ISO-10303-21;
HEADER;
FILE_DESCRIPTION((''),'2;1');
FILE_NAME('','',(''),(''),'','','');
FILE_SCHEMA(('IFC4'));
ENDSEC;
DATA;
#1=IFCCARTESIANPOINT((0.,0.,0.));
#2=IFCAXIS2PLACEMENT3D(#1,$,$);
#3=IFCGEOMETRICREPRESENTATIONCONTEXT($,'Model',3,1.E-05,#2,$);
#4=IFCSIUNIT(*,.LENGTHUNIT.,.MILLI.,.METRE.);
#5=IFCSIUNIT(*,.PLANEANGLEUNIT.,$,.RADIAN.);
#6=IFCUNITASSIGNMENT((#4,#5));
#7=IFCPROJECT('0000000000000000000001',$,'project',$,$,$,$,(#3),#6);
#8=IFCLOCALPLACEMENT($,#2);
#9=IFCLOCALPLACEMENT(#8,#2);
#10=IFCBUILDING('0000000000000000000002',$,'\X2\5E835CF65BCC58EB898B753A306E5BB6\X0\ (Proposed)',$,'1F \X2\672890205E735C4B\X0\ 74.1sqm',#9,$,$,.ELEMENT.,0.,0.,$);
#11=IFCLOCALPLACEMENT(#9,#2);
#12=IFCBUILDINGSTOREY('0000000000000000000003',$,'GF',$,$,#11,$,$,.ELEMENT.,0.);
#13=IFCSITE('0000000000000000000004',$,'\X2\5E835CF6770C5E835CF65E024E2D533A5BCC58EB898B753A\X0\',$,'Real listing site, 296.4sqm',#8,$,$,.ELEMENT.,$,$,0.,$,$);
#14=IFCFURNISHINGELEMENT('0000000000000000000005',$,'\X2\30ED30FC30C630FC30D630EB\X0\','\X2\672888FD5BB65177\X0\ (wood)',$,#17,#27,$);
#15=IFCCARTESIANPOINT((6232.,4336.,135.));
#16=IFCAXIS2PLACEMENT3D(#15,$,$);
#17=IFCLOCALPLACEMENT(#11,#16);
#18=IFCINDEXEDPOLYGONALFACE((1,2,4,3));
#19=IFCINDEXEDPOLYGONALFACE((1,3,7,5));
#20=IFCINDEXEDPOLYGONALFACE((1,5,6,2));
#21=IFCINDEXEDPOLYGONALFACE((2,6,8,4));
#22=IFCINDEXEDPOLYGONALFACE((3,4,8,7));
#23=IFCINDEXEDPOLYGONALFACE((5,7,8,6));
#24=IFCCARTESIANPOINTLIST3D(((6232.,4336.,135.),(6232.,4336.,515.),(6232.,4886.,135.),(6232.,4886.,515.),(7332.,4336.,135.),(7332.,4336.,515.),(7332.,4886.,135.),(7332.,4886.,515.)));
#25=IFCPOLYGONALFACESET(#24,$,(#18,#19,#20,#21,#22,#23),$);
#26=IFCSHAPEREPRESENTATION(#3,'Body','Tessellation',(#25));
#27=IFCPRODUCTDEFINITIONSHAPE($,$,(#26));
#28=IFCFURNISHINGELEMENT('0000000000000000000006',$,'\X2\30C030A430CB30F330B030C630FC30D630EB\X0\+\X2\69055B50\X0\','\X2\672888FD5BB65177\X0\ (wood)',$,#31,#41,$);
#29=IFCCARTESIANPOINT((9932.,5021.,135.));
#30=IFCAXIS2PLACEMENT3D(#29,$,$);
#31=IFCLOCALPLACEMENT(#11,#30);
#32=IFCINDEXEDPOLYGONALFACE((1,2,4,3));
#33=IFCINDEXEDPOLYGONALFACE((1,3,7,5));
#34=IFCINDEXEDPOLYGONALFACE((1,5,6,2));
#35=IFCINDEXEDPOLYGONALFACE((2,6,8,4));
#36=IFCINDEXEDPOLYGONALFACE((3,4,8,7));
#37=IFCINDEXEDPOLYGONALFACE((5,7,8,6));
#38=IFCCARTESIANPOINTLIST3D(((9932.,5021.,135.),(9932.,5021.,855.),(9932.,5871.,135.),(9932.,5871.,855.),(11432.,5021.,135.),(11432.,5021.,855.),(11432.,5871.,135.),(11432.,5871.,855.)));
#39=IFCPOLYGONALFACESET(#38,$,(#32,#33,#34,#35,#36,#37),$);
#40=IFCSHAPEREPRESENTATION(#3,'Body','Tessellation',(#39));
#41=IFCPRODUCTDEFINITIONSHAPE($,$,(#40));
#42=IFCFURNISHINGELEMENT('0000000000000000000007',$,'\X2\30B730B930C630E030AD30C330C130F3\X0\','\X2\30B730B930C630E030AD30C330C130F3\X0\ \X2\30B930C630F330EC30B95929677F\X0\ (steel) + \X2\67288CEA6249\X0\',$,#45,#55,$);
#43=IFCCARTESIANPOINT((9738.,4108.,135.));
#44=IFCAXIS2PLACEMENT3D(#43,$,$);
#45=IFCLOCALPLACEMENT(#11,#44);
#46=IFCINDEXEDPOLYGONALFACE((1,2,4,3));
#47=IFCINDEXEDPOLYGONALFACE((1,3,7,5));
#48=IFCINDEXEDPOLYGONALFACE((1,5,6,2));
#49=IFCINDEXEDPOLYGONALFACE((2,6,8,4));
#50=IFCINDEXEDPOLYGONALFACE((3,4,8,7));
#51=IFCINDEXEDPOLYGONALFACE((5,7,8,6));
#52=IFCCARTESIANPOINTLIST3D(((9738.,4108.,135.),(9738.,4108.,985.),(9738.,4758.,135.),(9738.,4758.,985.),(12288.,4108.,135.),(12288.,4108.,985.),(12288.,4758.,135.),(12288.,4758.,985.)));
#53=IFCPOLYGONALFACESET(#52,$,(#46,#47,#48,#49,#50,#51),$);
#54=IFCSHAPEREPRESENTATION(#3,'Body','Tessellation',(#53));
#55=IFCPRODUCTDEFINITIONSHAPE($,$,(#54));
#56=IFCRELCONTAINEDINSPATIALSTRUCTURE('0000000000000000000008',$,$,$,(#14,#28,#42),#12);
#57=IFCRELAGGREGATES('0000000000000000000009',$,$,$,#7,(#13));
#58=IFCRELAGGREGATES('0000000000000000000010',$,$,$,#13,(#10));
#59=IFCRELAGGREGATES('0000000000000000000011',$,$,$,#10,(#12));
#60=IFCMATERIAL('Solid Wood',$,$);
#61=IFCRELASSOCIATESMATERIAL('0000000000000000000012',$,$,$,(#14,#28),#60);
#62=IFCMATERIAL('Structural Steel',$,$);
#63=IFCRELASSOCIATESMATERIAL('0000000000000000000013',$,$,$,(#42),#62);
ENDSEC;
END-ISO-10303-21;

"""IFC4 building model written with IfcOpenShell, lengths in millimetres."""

from ifc_helpers import new_model, si_unit, frame, frame_2d, origin, place, context, project, spatial, rectangle, extrude, material, element, save


model = new_model("IFC4")

# Units and contexts
model_context = context("Model", 3, precision=1e-05, world=origin())
ifc_project = project(units=[si_unit("LENGTHUNIT", "METRE", prefix="MILLI"), si_unit("PLANEANGLEUNIT", "RADIAN")], contexts=[model_context])

# Site, building, storey
site_placement = place(None, origin())
site = spatial("IfcSite", under=ifc_project, at=site_placement, Name="広島県広島市中区富士見町", ObjectType="Real listing site, 296.4sqm", CompositionType="ELEMENT", RefElevation=0.0)
building_placement = place(site_placement, origin())
building = spatial("IfcBuilding", under=site, at=building_placement, Name="広島富士見町の家 (Proposed)", ObjectType="1F 木造平屋 74.1sqm", CompositionType="ELEMENT", ElevationOfRefHeight=0.0, ElevationOfTerrain=0.0)
storey_placement = place(building_placement, origin())
storey = spatial("IfcBuildingStorey", under=building, at=storey_placement, Name="GF", CompositionType="ELEMENT", Elevation=0.0)

# Shared definitions
ifc_material_1 = material(Name="Solid Wood")

# Furnishing elements
furnishing_1_placement = place(storey_placement, frame((6232.0, 4336.0, 135.0)))
element("IfcFurnishingElement", 1, at=furnishing_1_placement, inside=storey, material=ifc_material_1, Name="ローテーブル", Description="木製家具 (wood)", context=model_context, shape_type="SweptSolid", body=[
    extrude(rectangle(XDim=1100.0, YDim=550.0, at=frame_2d((550.0, 275.0))), frame((6232.0, 4336.0, 135.0)), (0.0, 0.0, 1.0), 380.0),
])
furnishing_2_placement = place(storey_placement, frame((9932.0, 5021.0, 135.0)))
element("IfcFurnishingElement", 2, at=furnishing_2_placement, inside=storey, material=ifc_material_1, Name="ダイニングテーブル+椅子", Description="木製家具 (wood)", context=model_context, shape_type="SweptSolid", body=[
    extrude(rectangle(XDim=1500.0, YDim=850.0, at=frame_2d((750.0, 425.0))), frame((9932.0, 5021.0, 135.0)), (0.0, 0.0, 1.0), 720.0),
])
ifc_material_2 = material(Name="Structural Steel")
furnishing_3_placement = place(storey_placement, frame((9738.0, 4108.0, 135.0)))
element("IfcFurnishingElement", 3, at=furnishing_3_placement, inside=storey, material=ifc_material_2, Name="システムキッチン", Description="システムキッチン ステンレス天板 (steel) + 木質扉", context=model_context, shape_type="SweptSolid", body=[
    extrude(rectangle(XDim=2550.0, YDim=650.0, at=frame_2d((1275.0, 325.0))), frame((9738.0, 4108.0, 135.0)), (0.0, 0.0, 1.0), 850.0),
])

save(model, "model.ifc")
